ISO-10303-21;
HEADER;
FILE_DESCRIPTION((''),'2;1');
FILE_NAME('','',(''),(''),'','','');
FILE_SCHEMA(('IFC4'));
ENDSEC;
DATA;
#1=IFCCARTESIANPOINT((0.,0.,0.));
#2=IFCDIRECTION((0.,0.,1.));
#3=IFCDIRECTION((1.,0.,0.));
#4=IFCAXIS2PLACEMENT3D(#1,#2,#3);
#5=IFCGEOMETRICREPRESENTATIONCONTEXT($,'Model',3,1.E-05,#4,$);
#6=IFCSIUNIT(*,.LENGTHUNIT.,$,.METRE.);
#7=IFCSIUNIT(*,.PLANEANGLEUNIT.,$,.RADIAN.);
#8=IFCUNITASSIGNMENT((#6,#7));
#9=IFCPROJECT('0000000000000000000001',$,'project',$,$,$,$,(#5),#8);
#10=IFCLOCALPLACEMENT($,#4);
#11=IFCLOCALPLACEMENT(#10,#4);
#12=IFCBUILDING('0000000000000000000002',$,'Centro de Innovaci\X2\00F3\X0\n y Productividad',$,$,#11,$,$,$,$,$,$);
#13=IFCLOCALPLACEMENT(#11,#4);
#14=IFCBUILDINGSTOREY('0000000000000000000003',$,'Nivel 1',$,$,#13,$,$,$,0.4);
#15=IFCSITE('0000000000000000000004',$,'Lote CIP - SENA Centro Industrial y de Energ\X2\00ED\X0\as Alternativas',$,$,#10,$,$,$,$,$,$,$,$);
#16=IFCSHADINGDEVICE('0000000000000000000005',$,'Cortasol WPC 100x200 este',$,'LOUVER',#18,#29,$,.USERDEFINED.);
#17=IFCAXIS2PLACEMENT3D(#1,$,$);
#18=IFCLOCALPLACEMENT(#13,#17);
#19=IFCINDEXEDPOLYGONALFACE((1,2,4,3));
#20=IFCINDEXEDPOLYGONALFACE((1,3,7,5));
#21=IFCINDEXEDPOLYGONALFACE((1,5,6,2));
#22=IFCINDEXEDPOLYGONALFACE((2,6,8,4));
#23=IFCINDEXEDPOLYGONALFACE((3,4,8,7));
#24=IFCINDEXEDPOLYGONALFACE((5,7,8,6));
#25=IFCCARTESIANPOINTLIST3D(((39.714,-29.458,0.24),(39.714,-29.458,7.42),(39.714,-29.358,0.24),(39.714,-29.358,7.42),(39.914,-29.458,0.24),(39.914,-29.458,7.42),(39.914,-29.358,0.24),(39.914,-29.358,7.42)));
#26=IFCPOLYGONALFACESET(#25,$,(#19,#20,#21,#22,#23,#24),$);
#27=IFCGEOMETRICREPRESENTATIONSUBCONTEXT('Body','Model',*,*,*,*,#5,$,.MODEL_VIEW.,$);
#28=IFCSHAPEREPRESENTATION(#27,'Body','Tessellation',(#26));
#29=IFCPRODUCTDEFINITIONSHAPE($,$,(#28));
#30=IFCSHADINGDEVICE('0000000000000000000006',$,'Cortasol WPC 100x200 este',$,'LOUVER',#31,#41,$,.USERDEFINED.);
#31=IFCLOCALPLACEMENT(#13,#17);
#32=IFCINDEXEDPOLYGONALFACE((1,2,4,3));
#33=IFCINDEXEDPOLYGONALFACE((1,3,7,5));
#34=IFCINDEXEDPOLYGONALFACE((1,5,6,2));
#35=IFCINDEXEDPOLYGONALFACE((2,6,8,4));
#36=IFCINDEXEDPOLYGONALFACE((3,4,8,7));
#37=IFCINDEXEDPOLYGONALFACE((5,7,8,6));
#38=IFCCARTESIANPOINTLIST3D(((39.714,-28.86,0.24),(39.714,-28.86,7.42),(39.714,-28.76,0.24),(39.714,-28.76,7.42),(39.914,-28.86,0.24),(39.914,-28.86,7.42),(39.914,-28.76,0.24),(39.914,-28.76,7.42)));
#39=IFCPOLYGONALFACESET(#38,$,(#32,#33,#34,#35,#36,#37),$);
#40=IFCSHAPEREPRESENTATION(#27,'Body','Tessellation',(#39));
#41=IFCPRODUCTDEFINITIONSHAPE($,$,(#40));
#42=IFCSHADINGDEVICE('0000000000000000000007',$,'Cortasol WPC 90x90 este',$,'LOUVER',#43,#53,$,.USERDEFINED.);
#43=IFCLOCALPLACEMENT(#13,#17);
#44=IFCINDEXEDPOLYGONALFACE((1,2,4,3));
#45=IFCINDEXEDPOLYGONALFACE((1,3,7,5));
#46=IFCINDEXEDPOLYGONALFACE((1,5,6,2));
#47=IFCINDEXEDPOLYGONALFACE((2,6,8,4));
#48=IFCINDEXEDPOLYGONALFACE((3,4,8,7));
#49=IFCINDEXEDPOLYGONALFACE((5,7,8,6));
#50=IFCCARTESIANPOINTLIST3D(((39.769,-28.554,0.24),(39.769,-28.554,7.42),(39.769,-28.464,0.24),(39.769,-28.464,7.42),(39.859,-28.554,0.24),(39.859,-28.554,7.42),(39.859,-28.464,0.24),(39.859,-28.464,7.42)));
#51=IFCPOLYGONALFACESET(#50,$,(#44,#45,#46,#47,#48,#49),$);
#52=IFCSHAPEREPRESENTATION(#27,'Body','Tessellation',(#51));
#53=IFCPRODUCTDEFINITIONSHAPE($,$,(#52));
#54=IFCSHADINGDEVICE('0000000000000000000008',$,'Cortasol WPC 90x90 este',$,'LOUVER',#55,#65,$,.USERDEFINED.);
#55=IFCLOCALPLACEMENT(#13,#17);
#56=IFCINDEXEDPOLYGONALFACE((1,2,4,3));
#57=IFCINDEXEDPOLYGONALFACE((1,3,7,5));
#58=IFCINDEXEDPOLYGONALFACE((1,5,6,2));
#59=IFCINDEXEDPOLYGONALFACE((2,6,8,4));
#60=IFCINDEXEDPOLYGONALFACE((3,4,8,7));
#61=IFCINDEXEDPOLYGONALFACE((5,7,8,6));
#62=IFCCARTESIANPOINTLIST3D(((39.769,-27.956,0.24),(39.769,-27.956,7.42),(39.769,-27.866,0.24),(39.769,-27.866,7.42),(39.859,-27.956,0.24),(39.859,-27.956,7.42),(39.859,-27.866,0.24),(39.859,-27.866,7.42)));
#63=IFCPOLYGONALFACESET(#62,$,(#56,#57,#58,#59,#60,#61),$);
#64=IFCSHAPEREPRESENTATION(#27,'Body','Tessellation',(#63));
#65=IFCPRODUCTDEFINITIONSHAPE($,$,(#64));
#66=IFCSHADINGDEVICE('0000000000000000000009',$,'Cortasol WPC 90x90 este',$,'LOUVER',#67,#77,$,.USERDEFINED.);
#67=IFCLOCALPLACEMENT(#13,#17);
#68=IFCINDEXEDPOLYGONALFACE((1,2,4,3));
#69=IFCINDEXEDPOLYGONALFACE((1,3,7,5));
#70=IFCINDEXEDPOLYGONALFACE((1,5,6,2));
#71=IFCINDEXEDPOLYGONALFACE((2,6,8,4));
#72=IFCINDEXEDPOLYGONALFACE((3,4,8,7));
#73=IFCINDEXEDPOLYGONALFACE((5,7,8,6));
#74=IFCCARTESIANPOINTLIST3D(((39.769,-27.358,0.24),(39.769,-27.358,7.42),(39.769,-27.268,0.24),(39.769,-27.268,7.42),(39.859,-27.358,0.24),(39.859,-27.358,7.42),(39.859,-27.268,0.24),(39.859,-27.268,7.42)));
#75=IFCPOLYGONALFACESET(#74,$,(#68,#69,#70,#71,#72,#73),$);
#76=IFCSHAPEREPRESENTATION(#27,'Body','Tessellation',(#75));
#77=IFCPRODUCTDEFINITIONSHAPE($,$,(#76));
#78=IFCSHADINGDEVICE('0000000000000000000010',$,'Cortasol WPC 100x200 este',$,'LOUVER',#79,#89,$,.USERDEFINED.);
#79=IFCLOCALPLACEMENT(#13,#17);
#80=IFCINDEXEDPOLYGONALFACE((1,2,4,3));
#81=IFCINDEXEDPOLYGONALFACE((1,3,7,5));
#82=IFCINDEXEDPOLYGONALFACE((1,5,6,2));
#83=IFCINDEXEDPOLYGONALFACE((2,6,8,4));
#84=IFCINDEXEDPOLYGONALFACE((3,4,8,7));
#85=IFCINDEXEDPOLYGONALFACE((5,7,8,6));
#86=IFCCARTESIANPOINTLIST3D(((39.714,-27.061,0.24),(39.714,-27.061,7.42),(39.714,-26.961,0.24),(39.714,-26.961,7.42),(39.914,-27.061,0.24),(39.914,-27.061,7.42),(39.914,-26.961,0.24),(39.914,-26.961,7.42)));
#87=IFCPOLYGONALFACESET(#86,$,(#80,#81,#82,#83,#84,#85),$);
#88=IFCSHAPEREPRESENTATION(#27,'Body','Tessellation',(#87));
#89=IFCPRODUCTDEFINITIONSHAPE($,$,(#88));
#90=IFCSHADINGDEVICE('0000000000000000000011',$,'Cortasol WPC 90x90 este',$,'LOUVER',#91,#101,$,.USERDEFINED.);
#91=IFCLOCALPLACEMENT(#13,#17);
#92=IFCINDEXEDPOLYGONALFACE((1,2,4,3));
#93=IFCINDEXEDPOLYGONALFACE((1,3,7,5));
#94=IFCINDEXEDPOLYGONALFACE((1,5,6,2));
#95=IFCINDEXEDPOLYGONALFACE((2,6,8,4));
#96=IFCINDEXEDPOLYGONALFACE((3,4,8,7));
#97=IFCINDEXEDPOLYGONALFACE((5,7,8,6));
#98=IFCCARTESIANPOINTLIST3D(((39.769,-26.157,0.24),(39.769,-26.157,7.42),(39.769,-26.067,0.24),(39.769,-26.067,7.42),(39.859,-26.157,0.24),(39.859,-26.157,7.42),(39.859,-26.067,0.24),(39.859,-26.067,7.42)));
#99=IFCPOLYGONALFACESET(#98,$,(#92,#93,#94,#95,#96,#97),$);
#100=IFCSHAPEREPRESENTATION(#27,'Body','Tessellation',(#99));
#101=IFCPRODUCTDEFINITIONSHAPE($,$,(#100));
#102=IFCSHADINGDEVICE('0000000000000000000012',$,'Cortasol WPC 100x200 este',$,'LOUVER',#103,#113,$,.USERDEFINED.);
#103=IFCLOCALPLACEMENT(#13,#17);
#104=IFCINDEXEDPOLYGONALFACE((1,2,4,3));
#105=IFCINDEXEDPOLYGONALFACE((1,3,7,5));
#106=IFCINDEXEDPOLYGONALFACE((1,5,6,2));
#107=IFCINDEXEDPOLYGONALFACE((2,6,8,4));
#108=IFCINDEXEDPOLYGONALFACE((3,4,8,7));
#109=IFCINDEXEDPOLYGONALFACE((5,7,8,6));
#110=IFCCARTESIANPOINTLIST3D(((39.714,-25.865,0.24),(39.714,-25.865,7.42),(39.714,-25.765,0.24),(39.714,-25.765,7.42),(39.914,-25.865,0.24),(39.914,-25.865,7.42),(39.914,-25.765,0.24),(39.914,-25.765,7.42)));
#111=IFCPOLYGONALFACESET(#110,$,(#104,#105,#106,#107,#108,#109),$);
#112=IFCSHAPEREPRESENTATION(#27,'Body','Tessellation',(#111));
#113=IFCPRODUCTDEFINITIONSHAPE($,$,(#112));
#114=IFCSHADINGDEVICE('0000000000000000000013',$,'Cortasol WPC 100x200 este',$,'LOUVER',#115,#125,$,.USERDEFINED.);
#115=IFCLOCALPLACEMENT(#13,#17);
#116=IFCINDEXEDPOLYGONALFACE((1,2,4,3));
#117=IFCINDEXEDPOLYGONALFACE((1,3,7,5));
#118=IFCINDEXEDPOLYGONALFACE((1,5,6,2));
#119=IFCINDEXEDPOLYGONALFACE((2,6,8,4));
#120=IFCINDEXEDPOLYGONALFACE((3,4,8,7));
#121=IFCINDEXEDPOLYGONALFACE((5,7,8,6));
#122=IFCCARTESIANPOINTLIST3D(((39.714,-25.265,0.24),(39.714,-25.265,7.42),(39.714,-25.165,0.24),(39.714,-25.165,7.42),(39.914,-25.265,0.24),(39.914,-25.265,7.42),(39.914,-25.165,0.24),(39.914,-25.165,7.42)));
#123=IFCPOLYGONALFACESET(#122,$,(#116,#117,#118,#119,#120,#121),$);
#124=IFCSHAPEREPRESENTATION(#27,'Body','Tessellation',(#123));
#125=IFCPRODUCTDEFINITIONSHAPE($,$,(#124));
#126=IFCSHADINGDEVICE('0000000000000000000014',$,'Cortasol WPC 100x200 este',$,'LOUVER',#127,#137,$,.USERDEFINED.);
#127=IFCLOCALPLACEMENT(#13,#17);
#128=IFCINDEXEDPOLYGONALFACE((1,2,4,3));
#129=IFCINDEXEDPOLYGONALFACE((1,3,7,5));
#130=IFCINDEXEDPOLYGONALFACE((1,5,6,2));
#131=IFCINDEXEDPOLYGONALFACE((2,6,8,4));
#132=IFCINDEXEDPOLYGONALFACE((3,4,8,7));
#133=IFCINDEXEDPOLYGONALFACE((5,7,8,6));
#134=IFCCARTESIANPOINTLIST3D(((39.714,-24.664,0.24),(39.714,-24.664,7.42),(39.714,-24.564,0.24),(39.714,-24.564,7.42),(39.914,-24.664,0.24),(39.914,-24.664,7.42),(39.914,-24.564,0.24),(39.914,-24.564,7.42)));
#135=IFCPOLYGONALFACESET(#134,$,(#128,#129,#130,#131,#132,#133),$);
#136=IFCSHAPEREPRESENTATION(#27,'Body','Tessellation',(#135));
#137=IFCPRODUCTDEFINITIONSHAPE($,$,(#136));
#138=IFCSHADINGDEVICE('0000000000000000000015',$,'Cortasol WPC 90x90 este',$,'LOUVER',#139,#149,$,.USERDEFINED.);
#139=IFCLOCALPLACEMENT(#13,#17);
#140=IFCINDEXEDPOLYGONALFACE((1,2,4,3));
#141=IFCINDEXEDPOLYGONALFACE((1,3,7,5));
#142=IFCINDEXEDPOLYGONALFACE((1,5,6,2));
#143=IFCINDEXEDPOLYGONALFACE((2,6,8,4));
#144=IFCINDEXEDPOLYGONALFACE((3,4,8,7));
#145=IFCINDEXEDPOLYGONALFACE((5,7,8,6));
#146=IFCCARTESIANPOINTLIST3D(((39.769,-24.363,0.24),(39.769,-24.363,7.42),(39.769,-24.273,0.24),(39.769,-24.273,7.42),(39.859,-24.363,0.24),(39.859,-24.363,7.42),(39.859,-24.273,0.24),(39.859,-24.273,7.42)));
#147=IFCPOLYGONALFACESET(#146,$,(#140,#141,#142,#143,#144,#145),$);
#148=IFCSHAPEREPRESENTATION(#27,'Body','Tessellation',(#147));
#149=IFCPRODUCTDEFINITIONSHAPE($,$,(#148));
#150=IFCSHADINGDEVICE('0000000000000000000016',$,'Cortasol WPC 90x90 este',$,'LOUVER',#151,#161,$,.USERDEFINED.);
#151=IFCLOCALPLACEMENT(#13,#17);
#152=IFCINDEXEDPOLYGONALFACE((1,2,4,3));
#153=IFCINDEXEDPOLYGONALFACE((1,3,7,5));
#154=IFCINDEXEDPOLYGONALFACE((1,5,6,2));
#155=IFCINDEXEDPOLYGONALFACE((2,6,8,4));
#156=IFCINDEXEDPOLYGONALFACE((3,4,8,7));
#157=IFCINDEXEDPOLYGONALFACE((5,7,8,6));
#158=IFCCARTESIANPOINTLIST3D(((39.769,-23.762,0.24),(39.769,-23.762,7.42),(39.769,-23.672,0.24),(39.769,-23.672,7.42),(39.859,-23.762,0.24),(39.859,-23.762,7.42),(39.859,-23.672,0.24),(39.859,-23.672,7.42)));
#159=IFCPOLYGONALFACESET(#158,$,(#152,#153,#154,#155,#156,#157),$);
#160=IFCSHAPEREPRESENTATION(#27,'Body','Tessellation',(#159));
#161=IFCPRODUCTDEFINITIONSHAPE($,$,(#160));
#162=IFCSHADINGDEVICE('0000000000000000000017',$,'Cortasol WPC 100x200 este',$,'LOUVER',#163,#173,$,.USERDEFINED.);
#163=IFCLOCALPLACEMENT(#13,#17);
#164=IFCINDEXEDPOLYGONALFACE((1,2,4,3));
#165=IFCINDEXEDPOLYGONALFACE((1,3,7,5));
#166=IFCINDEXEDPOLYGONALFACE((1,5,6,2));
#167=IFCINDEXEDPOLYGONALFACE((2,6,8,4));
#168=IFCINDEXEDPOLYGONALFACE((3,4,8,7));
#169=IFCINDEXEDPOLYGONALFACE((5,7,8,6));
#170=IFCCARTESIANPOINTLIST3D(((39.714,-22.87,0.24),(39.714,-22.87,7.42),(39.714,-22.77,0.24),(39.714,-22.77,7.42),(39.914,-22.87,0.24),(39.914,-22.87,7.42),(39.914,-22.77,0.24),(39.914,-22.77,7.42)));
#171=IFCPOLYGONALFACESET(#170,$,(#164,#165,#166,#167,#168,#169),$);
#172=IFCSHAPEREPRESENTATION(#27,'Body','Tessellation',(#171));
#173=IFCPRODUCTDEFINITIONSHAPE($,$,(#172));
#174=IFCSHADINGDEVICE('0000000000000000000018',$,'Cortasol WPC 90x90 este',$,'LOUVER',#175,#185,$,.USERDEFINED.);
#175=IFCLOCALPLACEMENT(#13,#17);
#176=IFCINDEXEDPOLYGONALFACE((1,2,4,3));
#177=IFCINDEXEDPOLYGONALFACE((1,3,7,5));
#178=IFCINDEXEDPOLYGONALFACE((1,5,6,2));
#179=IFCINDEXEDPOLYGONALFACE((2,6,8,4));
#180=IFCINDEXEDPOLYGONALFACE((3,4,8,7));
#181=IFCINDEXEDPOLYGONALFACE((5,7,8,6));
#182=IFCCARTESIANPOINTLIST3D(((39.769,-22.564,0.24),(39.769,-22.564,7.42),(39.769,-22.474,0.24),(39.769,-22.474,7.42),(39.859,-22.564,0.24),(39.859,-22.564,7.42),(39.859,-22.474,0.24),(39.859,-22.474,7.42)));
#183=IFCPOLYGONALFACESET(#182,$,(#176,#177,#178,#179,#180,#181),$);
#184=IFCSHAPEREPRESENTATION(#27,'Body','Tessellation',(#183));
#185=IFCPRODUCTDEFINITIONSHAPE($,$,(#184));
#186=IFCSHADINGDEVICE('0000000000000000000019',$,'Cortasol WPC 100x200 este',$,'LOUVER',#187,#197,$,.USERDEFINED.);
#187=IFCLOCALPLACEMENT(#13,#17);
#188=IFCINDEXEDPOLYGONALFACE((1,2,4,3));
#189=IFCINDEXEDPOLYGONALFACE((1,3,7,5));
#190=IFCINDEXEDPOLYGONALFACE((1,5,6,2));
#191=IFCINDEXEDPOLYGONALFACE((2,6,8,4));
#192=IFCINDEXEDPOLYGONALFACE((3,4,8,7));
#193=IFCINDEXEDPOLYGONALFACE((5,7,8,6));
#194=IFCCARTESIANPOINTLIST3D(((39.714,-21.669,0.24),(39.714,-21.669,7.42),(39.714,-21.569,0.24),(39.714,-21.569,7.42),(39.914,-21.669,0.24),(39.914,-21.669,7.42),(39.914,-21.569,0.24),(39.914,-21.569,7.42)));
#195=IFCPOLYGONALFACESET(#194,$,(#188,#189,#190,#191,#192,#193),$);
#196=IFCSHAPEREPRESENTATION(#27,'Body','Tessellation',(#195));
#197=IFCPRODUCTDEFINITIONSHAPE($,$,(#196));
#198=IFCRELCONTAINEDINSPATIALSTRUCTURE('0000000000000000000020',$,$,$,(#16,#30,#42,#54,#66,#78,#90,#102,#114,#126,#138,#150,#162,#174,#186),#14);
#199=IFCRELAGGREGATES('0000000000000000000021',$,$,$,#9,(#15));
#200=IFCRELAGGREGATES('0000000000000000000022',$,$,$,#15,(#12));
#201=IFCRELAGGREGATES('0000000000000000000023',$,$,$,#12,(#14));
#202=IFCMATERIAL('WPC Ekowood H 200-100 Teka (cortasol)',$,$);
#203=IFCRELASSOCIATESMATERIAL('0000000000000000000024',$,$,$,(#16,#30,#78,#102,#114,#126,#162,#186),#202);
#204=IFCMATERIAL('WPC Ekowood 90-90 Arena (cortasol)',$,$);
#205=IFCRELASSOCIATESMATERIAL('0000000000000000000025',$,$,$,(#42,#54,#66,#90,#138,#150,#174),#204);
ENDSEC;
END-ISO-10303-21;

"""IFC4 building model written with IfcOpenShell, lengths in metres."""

from ifc_helpers import new_model, si_unit, frame, origin_with_axes, place, context, subcontext, project, spatial, polyline, outline, extrude, material, element, save


model = new_model("IFC4")

# Units and contexts
model_context = context("Model", 3, precision=1e-05, world=origin_with_axes())
body_context = subcontext(model_context, "Body", "Model", "MODEL_VIEW")
ifc_project = project(units=[si_unit("LENGTHUNIT", "METRE"), si_unit("PLANEANGLEUNIT", "RADIAN")], contexts=[model_context])

# Site, building, storey
site_placement = place(None, origin_with_axes())
site = spatial("IfcSite", under=ifc_project, at=site_placement, Name="Lote CIP - SENA Centro Industrial y de Energías Alternativas")
building_placement = place(site_placement, origin_with_axes())
building = spatial("IfcBuilding", under=site, at=building_placement, Name="Centro de Innovación y Productividad")
storey_placement = place(building_placement, origin_with_axes())
storey = spatial("IfcBuildingStorey", under=building, at=storey_placement, Name="Nivel 1", Elevation=0.4)

# Shading devices
ifc_material_1 = material(Name="WPC Ekowood H 200-100 Teka (cortasol)")
shading_device_1_placement = place(storey_placement, origin_with_axes())
element("IfcShadingDevice", 1, at=shading_device_1_placement, inside=storey, material=ifc_material_1, Name="Cortasol WPC 100x200 este", ObjectType="LOUVER", PredefinedType="USERDEFINED", context=body_context, shape_type="SweptSolid", body=[
    extrude(outline(polyline([(39.914, -29.458), (39.714, -29.458), (39.714, -29.358), (39.914, -29.358), (39.914, -29.458)])), frame((0.0, 0.0, 0.24)), (0.0, 0.0, 1.0), 7.18),
])
shading_device_2_placement = place(storey_placement, origin_with_axes())
element("IfcShadingDevice", 2, at=shading_device_2_placement, inside=storey, material=ifc_material_1, Name="Cortasol WPC 100x200 este", ObjectType="LOUVER", PredefinedType="USERDEFINED", context=body_context, shape_type="SweptSolid", body=[
    extrude(outline(polyline([(39.914, -28.86), (39.714, -28.86), (39.714, -28.76), (39.914, -28.76), (39.914, -28.86)])), frame((0.0, 0.0, 0.24)), (0.0, 0.0, 1.0), 7.18),
])
ifc_material_2 = material(Name="WPC Ekowood 90-90 Arena (cortasol)")
shading_device_3_placement = place(storey_placement, origin_with_axes())
element("IfcShadingDevice", 3, at=shading_device_3_placement, inside=storey, material=ifc_material_2, Name="Cortasol WPC 90x90 este", ObjectType="LOUVER", PredefinedType="USERDEFINED", context=body_context, shape_type="SweptSolid", body=[
    extrude(outline(polyline([(39.859, -28.554), (39.769, -28.554), (39.769, -28.464), (39.859, -28.464), (39.859, -28.554)])), frame((0.0, 0.0, 0.24)), (0.0, 0.0, 1.0), 7.18),
])
shading_device_4_placement = place(storey_placement, origin_with_axes())
element("IfcShadingDevice", 4, at=shading_device_4_placement, inside=storey, material=ifc_material_2, Name="Cortasol WPC 90x90 este", ObjectType="LOUVER", PredefinedType="USERDEFINED", context=body_context, shape_type="SweptSolid", body=[
    extrude(outline(polyline([(39.859, -27.956), (39.769, -27.956), (39.769, -27.866), (39.859, -27.866), (39.859, -27.956)])), frame((0.0, 0.0, 0.24)), (0.0, 0.0, 1.0), 7.18),
])
shading_device_5_placement = place(storey_placement, origin_with_axes())
element("IfcShadingDevice", 5, at=shading_device_5_placement, inside=storey, material=ifc_material_2, Name="Cortasol WPC 90x90 este", ObjectType="LOUVER", PredefinedType="USERDEFINED", context=body_context, shape_type="SweptSolid", body=[
    extrude(outline(polyline([(39.859, -27.358), (39.769, -27.358), (39.769, -27.268), (39.859, -27.268), (39.859, -27.358)])), frame((0.0, 0.0, 0.24)), (0.0, 0.0, 1.0), 7.18),
])
shading_device_6_placement = place(storey_placement, origin_with_axes())
element("IfcShadingDevice", 6, at=shading_device_6_placement, inside=storey, material=ifc_material_1, Name="Cortasol WPC 100x200 este", ObjectType="LOUVER", PredefinedType="USERDEFINED", context=body_context, shape_type="SweptSolid", body=[
    extrude(outline(polyline([(39.914, -27.061), (39.714, -27.061), (39.714, -26.961), (39.914, -26.961), (39.914, -27.061)])), frame((0.0, 0.0, 0.24)), (0.0, 0.0, 1.0), 7.18),
])
shading_device_7_placement = place(storey_placement, origin_with_axes())
element("IfcShadingDevice", 7, at=shading_device_7_placement, inside=storey, material=ifc_material_2, Name="Cortasol WPC 90x90 este", ObjectType="LOUVER", PredefinedType="USERDEFINED", context=body_context, shape_type="SweptSolid", body=[
    extrude(outline(polyline([(39.859, -26.157), (39.769, -26.157), (39.769, -26.067), (39.859, -26.067), (39.859, -26.157)])), frame((0.0, 0.0, 0.24)), (0.0, 0.0, 1.0), 7.18),
])
shading_device_8_placement = place(storey_placement, origin_with_axes())
element("IfcShadingDevice", 8, at=shading_device_8_placement, inside=storey, material=ifc_material_1, Name="Cortasol WPC 100x200 este", ObjectType="LOUVER", PredefinedType="USERDEFINED", context=body_context, shape_type="SweptSolid", body=[
    extrude(outline(polyline([(39.914, -25.865), (39.714, -25.865), (39.714, -25.765), (39.914, -25.765), (39.914, -25.865)])), frame((0.0, 0.0, 0.24)), (0.0, 0.0, 1.0), 7.18),
])
shading_device_9_placement = place(storey_placement, origin_with_axes())
element("IfcShadingDevice", 9, at=shading_device_9_placement, inside=storey, material=ifc_material_1, Name="Cortasol WPC 100x200 este", ObjectType="LOUVER", PredefinedType="USERDEFINED", context=body_context, shape_type="SweptSolid", body=[
    extrude(outline(polyline([(39.914, -25.265), (39.714, -25.265), (39.714, -25.165), (39.914, -25.165), (39.914, -25.265)])), frame((0.0, 0.0, 0.24)), (0.0, 0.0, 1.0), 7.18),
])
shading_device_10_placement = place(storey_placement, origin_with_axes())
element("IfcShadingDevice", 10, at=shading_device_10_placement, inside=storey, material=ifc_material_1, Name="Cortasol WPC 100x200 este", ObjectType="LOUVER", PredefinedType="USERDEFINED", context=body_context, shape_type="SweptSolid", body=[
    extrude(outline(polyline([(39.914, -24.664), (39.714, -24.664), (39.714, -24.564), (39.914, -24.564), (39.914, -24.664)])), frame((0.0, 0.0, 0.24)), (0.0, 0.0, 1.0), 7.18),
])
shading_device_11_placement = place(storey_placement, origin_with_axes())
element("IfcShadingDevice", 11, at=shading_device_11_placement, inside=storey, material=ifc_material_2, Name="Cortasol WPC 90x90 este", ObjectType="LOUVER", PredefinedType="USERDEFINED", context=body_context, shape_type="SweptSolid", body=[
    extrude(outline(polyline([(39.859, -24.363), (39.769, -24.363), (39.769, -24.273), (39.859, -24.273), (39.859, -24.363)])), frame((0.0, 0.0, 0.24)), (0.0, 0.0, 1.0), 7.18),
])
shading_device_12_placement = place(storey_placement, origin_with_axes())
element("IfcShadingDevice", 12, at=shading_device_12_placement, inside=storey, material=ifc_material_2, Name="Cortasol WPC 90x90 este", ObjectType="LOUVER", PredefinedType="USERDEFINED", context=body_context, shape_type="SweptSolid", body=[
    extrude(outline(polyline([(39.859, -23.762), (39.769, -23.762), (39.769, -23.672), (39.859, -23.672), (39.859, -23.762)])), frame((0.0, 0.0, 0.24)), (0.0, 0.0, 1.0), 7.18),
])
shading_device_13_placement = place(storey_placement, origin_with_axes())
element("IfcShadingDevice", 13, at=shading_device_13_placement, inside=storey, material=ifc_material_1, Name="Cortasol WPC 100x200 este", ObjectType="LOUVER", PredefinedType="USERDEFINED", context=body_context, shape_type="SweptSolid", body=[
    extrude(outline(polyline([(39.914, -22.87), (39.714, -22.87), (39.714, -22.77), (39.914, -22.77), (39.914, -22.87)])), frame((0.0, 0.0, 0.24)), (0.0, 0.0, 1.0), 7.18),
])
shading_device_14_placement = place(storey_placement, origin_with_axes())
element("IfcShadingDevice", 14, at=shading_device_14_placement, inside=storey, material=ifc_material_2, Name="Cortasol WPC 90x90 este", ObjectType="LOUVER", PredefinedType="USERDEFINED", context=body_context, shape_type="SweptSolid", body=[
    extrude(outline(polyline([(39.859, -22.564), (39.769, -22.564), (39.769, -22.474), (39.859, -22.474), (39.859, -22.564)])), frame((0.0, 0.0, 0.24)), (0.0, 0.0, 1.0), 7.18),
])
shading_device_15_placement = place(storey_placement, origin_with_axes())
element("IfcShadingDevice", 15, at=shading_device_15_placement, inside=storey, material=ifc_material_1, Name="Cortasol WPC 100x200 este", ObjectType="LOUVER", PredefinedType="USERDEFINED", context=body_context, shape_type="SweptSolid", body=[
    extrude(outline(polyline([(39.914, -21.669), (39.714, -21.669), (39.714, -21.569), (39.914, -21.569), (39.914, -21.669)])), frame((0.0, 0.0, 0.24)), (0.0, 0.0, 1.0), 7.18),
])

save(model, "model.ifc")
